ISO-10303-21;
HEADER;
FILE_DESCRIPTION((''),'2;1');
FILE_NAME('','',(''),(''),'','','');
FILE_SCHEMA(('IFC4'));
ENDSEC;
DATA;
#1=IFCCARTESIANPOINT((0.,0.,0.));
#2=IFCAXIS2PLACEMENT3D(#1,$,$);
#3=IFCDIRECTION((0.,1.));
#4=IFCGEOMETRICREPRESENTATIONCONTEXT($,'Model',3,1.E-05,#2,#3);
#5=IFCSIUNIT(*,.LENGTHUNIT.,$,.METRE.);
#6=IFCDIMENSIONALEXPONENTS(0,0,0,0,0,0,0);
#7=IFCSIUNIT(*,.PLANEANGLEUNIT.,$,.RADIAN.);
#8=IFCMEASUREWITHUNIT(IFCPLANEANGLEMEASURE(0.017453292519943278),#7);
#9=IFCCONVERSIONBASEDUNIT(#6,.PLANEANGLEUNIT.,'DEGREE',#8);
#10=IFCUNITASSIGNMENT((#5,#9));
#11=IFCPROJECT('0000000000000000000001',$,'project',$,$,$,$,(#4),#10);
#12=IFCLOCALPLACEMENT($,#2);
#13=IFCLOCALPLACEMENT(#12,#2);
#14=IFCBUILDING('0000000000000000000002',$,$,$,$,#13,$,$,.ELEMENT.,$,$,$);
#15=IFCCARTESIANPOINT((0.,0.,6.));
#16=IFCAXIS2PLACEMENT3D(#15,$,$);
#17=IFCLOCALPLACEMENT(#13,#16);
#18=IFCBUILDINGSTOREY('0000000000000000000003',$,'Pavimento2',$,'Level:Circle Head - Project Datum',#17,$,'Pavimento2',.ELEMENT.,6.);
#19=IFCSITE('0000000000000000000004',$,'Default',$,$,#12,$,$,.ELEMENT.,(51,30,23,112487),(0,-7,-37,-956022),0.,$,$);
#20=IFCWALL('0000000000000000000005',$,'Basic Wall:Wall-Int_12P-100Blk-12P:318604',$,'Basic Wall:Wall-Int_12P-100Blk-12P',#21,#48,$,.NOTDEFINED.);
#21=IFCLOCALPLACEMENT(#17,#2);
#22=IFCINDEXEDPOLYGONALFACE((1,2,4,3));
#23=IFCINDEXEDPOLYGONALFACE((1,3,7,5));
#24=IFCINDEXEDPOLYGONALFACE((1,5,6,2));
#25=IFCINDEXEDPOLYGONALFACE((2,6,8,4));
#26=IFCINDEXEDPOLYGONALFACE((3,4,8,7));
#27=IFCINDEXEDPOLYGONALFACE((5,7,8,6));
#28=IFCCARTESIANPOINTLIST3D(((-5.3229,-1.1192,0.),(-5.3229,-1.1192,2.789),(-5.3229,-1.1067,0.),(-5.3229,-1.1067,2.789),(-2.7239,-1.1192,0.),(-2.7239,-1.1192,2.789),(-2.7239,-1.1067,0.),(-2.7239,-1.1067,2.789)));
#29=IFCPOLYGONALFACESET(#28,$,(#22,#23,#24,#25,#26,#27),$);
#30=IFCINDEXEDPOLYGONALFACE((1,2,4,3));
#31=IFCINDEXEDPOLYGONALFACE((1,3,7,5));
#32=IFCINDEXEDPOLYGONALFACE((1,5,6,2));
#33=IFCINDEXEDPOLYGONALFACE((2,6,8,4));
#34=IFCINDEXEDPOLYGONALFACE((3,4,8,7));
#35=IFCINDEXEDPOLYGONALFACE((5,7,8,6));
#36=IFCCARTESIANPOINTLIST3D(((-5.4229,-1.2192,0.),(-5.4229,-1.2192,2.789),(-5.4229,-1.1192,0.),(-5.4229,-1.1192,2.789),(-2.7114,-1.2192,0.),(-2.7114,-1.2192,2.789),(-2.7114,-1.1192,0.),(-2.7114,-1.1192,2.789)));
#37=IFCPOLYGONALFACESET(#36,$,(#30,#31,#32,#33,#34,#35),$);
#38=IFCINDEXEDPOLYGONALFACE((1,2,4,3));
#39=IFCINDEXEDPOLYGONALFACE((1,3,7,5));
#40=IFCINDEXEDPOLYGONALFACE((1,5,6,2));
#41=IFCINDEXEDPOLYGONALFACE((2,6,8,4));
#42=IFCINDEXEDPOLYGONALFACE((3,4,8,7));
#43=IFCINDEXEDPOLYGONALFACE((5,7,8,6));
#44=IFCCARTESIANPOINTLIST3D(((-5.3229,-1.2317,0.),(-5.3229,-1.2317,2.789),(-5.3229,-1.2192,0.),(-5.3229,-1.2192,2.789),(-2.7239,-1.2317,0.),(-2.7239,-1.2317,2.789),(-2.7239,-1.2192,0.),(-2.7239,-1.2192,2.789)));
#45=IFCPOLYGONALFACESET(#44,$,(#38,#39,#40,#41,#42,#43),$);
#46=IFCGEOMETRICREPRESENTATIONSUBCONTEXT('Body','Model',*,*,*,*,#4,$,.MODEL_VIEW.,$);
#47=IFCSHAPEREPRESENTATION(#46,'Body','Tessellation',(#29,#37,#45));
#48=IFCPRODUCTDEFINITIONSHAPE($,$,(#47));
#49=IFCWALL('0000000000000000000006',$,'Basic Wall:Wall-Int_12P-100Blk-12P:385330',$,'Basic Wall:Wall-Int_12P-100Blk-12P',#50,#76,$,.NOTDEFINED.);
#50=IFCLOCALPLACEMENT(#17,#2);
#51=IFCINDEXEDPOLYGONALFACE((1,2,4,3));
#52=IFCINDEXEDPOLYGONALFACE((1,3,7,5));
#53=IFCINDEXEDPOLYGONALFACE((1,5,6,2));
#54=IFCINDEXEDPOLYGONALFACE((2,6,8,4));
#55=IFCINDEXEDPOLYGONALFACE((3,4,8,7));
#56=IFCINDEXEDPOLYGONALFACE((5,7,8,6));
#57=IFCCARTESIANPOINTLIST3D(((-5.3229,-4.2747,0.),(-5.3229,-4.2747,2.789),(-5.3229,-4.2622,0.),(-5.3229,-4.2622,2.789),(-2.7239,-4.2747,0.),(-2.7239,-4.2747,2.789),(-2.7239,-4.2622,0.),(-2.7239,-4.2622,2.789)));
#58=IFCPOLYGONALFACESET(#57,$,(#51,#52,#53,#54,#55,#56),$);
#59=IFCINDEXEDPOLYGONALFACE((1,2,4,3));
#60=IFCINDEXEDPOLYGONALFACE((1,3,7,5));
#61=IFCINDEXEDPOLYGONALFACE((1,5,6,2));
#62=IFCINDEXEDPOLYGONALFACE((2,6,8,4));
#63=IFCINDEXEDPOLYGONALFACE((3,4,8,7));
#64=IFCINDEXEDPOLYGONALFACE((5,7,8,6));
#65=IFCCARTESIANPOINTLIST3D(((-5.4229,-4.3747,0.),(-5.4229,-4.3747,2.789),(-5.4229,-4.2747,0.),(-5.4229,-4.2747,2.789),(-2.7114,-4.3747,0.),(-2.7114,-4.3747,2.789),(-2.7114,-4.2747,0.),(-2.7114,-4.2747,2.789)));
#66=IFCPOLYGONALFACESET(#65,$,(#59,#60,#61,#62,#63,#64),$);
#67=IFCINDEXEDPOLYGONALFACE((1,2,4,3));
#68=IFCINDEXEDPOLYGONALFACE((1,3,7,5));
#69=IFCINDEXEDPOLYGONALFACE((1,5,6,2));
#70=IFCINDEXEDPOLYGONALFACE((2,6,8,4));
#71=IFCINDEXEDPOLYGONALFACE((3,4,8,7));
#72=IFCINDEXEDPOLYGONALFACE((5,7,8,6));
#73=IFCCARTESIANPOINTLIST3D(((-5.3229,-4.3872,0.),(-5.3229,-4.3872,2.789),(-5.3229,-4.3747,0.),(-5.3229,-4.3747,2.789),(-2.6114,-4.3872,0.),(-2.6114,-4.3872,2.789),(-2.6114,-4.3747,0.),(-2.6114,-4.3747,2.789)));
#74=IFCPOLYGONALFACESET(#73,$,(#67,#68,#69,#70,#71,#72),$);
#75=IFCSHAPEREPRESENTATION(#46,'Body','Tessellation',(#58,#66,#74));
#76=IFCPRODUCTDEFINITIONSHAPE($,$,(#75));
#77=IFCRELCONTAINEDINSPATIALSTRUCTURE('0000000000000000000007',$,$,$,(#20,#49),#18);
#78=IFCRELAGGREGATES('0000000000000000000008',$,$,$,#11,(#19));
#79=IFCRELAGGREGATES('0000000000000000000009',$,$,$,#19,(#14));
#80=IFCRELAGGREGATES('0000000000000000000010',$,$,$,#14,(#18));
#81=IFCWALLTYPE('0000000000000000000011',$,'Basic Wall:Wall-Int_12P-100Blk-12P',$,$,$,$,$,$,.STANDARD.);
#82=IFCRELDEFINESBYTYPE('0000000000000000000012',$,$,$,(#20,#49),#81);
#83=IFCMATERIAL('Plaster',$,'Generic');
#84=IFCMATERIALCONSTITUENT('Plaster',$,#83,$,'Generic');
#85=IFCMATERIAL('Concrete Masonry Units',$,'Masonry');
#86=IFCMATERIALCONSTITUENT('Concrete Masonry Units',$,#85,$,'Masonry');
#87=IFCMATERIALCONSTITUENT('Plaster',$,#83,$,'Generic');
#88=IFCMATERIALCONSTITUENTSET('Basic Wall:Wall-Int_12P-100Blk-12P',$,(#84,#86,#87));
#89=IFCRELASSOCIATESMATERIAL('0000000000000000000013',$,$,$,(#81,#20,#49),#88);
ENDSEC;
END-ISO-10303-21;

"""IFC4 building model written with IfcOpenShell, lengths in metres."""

from ifc_helpers import new_model, entity, si_unit, converted_unit, direction, frame, origin, place, context, subcontext, project, spatial, indexed_curve, outline, extrude, material, constituent, constituent_set, type_object, element, save


model = new_model("IFC4")

# Units and contexts
model_context = context("Model", 3, precision=1e-05, world=origin(), true_north=direction((0.0, 1.0)))
body_context = subcontext(model_context, "Body", "Model", "MODEL_VIEW")
ifc_project = project(units=[si_unit("LENGTHUNIT", "METRE"), converted_unit("PLANEANGLEUNIT", "DEGREE", entity("IfcPlaneAngleMeasure", 0.017453292519943278), si_unit("PLANEANGLEUNIT", "RADIAN"), dimensions=[0, 0, 0, 0, 0, 0, 0])], contexts=[model_context])

# Site, building, storey
site_placement = place(None, origin())
site = spatial("IfcSite", under=ifc_project, at=site_placement, Name="Default", CompositionType="ELEMENT", RefLatitude=(51, 30, 23, 112487), RefLongitude=(0, -7, -37, -956022), RefElevation=0.0)
building_placement = place(site_placement, origin())
building = spatial("IfcBuilding", under=site, at=building_placement, CompositionType="ELEMENT")
storey_placement = place(building_placement, frame((0.0, 0.0, 6.0)))
storey = spatial("IfcBuildingStorey", under=building, at=storey_placement, Name="Pavimento2", ObjectType="Level:Circle Head - Project Datum", LongName="Pavimento2", CompositionType="ELEMENT", Elevation=6.0)

# Shared definitions
ifc_material_1 = material(Name="Plaster", Category="Generic")

# Shared definitions
ifc_constituent_1 = constituent(ifc_material_1, Name="Plaster", Category="Generic")
ifc_material_2 = material(Name="Concrete Masonry Units", Category="Masonry")
ifc_constituent_2 = constituent(ifc_material_2, Name="Concrete Masonry Units", Category="Masonry")
ifc_constituent_3 = constituent(ifc_material_1, Name="Plaster", Category="Generic")
ifc_constituent_set_1 = constituent_set(constituents=[ifc_constituent_1, ifc_constituent_2, ifc_constituent_3], Name="Basic Wall:Wall-Int_12P-100Blk-12P")
wall_type_1 = type_object("IfcWallType", Name="Basic Wall:Wall-Int_12P-100Blk-12P", PredefinedType="STANDARD", material=ifc_constituent_set_1)

# Wall
wall_1_placement = place(storey_placement, frame((-2.7239, -1.1692, 0.0), z_axis=(0.0, 0.0, 1.0), x_axis=(-1.0, 0.0, 0.0)))
element("IfcWall", 1, at=wall_1_placement, inside=storey, type_object=wall_type_1, material=ifc_constituent_set_1, Name="Basic Wall:Wall-Int_12P-100Blk-12P:318604", ObjectType="Basic Wall:Wall-Int_12P-100Blk-12P", PredefinedType="NOTDEFINED", context=body_context, shape_type="SweptSolid", body=[
    extrude(outline(indexed_curve([(-0.0063, -1.2995), (0.0062, -1.2995), (0.0063, 1.2995), (-0.0062, 1.2995), (-0.0063, -1.2995)], self_intersect=False)), frame((1.2995, -0.0563, 0.0), z_axis=(0.0, 0.0, 1.0), x_axis=(0.0, 1.0, 0.0)), (0.0, 0.0, 1.0), 2.789),
    extrude(outline(indexed_curve([(-1.3558, -0.05), (1.3558, -0.05), (1.3558, 0.05), (-1.3558, 0.05), (-1.3558, -0.05)], self_intersect=False)), frame((1.3433, 0.0, 0.0)), (0.0, 0.0, 1.0), 2.789),
    extrude(outline(indexed_curve([(-0.0063, -1.2995), (0.0062, -1.2995), (0.0063, 1.2995), (-0.0062, 1.2995), (-0.0063, -1.2995)], self_intersect=False)), frame((1.2995, 0.0562, 0.0), z_axis=(0.0, 0.0, 1.0), x_axis=(0.0, -1.0, 0.0)), (0.0, 0.0, 1.0), 2.789),
])

# Wall
wall_2_placement = place(storey_placement, frame((-2.7239, -4.3247, 0.0), z_axis=(0.0, 0.0, 1.0), x_axis=(-1.0, 0.0, 0.0)))
element("IfcWall", 2, at=wall_2_placement, inside=storey, type_object=wall_type_1, material=ifc_constituent_set_1, Name="Basic Wall:Wall-Int_12P-100Blk-12P:385330", ObjectType="Basic Wall:Wall-Int_12P-100Blk-12P", PredefinedType="NOTDEFINED", context=body_context, shape_type="SweptSolid", body=[
    extrude(outline(indexed_curve([(-0.0063, -1.2995), (0.0062, -1.2995), (0.0063, 1.2995), (-0.0062, 1.2995), (-0.0063, -1.2995)], self_intersect=False)), frame((1.2995, -0.0563, 0.0), z_axis=(0.0, 0.0, 1.0), x_axis=(0.0, 1.0, 0.0)), (0.0, 0.0, 1.0), 2.789),
    extrude(outline(indexed_curve([(-1.3558, -0.05), (1.3558, -0.05), (1.3558, 0.05), (-1.3558, 0.05), (-1.3558, -0.05)], self_intersect=False)), frame((1.3433, 0.0, 0.0)), (0.0, 0.0, 1.0), 2.789),
    extrude(outline(indexed_curve([(-0.0063, -1.3558), (0.0062, -1.3558), (0.0063, 1.3558), (-0.0062, 1.3558), (-0.0063, -1.3558)], self_intersect=False)), frame((1.2433, 0.0563, 0.0), z_axis=(0.0, 0.0, 1.0), x_axis=(0.0, -1.0, 0.0)), (0.0, 0.0, 1.0), 2.789),
])

save(model, "model.ifc")
